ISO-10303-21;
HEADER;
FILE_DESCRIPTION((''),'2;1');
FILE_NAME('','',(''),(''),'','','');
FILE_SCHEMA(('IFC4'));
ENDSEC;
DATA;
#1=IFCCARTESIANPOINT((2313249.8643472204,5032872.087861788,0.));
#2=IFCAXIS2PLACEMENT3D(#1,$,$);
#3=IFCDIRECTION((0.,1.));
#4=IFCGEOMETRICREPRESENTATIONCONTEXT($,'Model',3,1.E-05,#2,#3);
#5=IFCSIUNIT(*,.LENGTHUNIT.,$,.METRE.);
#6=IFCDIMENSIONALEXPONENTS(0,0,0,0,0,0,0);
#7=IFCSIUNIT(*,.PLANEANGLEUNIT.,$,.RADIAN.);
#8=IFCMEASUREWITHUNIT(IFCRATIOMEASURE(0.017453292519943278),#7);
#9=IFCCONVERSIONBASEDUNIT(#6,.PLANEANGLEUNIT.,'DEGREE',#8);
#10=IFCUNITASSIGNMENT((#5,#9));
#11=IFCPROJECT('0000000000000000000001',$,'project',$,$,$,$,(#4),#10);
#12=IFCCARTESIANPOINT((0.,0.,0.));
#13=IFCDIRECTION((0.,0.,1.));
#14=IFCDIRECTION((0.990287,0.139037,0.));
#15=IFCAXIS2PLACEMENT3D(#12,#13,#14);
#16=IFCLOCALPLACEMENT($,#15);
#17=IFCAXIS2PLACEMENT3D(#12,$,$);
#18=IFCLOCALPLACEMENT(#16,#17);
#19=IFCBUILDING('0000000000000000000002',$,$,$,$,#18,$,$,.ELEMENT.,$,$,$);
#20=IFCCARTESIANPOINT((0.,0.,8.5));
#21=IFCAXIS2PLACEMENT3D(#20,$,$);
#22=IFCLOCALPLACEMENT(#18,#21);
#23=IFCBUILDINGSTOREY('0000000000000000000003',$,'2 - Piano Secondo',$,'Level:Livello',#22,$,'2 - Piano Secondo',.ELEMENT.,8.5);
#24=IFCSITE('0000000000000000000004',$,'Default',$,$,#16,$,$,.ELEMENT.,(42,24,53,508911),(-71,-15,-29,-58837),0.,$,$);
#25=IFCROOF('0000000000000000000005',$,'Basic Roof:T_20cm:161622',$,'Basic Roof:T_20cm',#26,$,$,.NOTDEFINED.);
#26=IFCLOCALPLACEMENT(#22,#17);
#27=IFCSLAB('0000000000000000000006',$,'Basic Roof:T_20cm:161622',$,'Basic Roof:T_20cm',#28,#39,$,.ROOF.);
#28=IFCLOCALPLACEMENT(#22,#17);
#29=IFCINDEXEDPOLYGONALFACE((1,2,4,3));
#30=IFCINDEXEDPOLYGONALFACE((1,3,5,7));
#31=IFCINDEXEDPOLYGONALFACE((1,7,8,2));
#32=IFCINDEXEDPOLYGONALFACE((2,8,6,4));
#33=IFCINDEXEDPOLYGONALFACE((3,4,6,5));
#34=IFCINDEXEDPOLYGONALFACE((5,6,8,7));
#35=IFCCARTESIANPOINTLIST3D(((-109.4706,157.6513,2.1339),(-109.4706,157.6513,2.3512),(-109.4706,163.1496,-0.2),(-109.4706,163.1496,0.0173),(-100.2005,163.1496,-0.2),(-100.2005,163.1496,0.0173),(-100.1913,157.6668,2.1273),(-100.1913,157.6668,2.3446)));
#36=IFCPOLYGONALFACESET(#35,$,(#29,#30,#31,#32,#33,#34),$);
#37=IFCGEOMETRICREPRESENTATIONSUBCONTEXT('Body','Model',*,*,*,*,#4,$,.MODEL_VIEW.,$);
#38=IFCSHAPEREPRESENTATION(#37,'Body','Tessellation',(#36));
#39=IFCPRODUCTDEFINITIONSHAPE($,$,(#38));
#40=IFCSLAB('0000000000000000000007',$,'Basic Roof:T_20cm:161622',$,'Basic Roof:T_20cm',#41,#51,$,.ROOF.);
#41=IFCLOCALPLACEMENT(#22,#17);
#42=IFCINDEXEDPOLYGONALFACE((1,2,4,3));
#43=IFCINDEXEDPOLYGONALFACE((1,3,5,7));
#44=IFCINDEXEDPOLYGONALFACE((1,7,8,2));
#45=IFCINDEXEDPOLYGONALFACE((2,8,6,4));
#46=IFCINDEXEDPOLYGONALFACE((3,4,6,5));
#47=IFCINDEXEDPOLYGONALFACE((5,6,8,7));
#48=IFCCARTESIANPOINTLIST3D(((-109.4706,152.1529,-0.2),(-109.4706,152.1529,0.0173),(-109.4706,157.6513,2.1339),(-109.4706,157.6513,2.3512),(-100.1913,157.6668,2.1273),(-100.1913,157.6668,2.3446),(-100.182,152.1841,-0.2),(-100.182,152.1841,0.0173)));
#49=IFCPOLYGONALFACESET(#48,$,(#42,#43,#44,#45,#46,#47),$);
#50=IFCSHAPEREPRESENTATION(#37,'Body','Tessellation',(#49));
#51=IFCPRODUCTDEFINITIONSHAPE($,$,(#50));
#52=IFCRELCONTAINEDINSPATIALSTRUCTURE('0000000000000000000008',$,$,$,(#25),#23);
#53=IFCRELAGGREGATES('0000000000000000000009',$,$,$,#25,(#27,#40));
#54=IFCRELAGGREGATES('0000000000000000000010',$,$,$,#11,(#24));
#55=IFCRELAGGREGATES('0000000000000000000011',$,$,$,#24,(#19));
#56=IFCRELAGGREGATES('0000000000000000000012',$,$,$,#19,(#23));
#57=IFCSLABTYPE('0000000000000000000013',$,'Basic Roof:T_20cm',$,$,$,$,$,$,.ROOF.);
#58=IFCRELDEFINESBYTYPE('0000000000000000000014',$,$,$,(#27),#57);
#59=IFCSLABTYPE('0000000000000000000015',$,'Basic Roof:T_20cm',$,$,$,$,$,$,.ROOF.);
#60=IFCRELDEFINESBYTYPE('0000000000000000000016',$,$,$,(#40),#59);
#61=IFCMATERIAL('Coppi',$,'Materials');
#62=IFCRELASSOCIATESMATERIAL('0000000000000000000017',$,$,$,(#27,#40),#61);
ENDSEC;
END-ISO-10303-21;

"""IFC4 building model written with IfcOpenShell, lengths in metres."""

from ifc_helpers import new_model, entity, si_unit, converted_unit, direction, frame, origin, place, context, subcontext, project, spatial, indexed_curve, outline, extrude, material, type_object, element, aggregate, save


model = new_model("IFC4")

# Units and contexts
model_context = context("Model", 3, precision=1e-05, world=frame((2313249.8643472204, 5032872.087861788, 0.0)), true_north=direction((0.0, 1.0)))
body_context = subcontext(model_context, "Body", "Model", "MODEL_VIEW")
ifc_project = project(units=[si_unit("LENGTHUNIT", "METRE"), converted_unit("PLANEANGLEUNIT", "DEGREE", entity("IfcRatioMeasure", 0.017453292519943278), si_unit("PLANEANGLEUNIT", "RADIAN"), dimensions=[0, 0, 0, 0, 0, 0, 0])], contexts=[model_context])

# Site, building, storey
site_placement = place(None, frame((0.0, 0.0, 0.0), z_axis=(0.0, 0.0, 1.0), x_axis=(0.990287, 0.139037, 0.0)))
site = spatial("IfcSite", under=ifc_project, at=site_placement, Name="Default", CompositionType="ELEMENT", RefLatitude=(42, 24, 53, 508911), RefLongitude=(-71, -15, -29, -58837), RefElevation=0.0)
building_placement = place(site_placement, origin())
building = spatial("IfcBuilding", under=site, at=building_placement, CompositionType="ELEMENT")
storey_placement = place(building_placement, frame((0.0, 0.0, 8.5)))
storey = spatial("IfcBuildingStorey", under=building, at=storey_placement, Name="2 - Piano Secondo", ObjectType="Level:Livello", LongName="2 - Piano Secondo", CompositionType="ELEMENT", Elevation=8.5)

# Roof, slabs
ifc_material_1 = material(Name="Coppi", Category="Materials")
roof_1_placement = place(storey_placement, frame((-109.4706, 152.1529, -0.2)))
roof_1 = element("IfcRoof", 1, at=roof_1_placement, inside=storey, Name="Basic Roof:T_20cm:161622", ObjectType="Basic Roof:T_20cm", PredefinedType="NOTDEFINED")
slab_type_1 = type_object("IfcSlabType", Name="Basic Roof:T_20cm", PredefinedType="ROOF")
slab_1_placement = place(roof_1_placement, origin())
slab_1 = element("IfcSlab", 2, at=slab_1_placement, type_object=slab_type_1, material=ifc_material_1, Name="Basic Roof:T_20cm:161622", ObjectType="Basic Roof:T_20cm", PredefinedType="ROOF", context=body_context, shape_type="SweptSolid", body=[
    extrude(outline(indexed_curve([(-4.6397, 2.9866), (-4.6397, -2.9866), (4.6397, -2.9697), (4.6304, 2.9866), (-4.6397, 2.9866)], self_intersect=False)), frame((4.6397, 8.2475, 1.1669), z_axis=(0.0, 0.390731, 0.920505), x_axis=(1.0, 0.0, 0.0)), (0.0, -0.390731, 0.920505), 0.2173),
])
slab_type_2 = type_object("IfcSlabType", Name="Basic Roof:T_20cm", PredefinedType="ROOF")
slab_2_placement = place(roof_1_placement, origin())
slab_2 = element("IfcSlab", 3, at=slab_2_placement, type_object=slab_type_2, material=ifc_material_1, Name="Basic Roof:T_20cm:161622", ObjectType="Basic Roof:T_20cm", PredefinedType="ROOF", context=body_context, shape_type="SweptSolid", body=[
    extrude(outline(indexed_curve([(4.6397, 2.984), (-4.6397, 2.9723), (-4.6397, -3.0009), (4.649, -2.9723), (4.6397, 2.984)], self_intersect=False)), frame((4.6397, 2.7647, 1.1669), z_axis=(0.001309, -0.390729, 0.920505), x_axis=(0.999999, 0.000511, -0.001205)), (-0.001205, 0.390729, 0.920505), 0.2173),
])
aggregate(roof_1, [slab_1, slab_2])

save(model, "model.ifc")
